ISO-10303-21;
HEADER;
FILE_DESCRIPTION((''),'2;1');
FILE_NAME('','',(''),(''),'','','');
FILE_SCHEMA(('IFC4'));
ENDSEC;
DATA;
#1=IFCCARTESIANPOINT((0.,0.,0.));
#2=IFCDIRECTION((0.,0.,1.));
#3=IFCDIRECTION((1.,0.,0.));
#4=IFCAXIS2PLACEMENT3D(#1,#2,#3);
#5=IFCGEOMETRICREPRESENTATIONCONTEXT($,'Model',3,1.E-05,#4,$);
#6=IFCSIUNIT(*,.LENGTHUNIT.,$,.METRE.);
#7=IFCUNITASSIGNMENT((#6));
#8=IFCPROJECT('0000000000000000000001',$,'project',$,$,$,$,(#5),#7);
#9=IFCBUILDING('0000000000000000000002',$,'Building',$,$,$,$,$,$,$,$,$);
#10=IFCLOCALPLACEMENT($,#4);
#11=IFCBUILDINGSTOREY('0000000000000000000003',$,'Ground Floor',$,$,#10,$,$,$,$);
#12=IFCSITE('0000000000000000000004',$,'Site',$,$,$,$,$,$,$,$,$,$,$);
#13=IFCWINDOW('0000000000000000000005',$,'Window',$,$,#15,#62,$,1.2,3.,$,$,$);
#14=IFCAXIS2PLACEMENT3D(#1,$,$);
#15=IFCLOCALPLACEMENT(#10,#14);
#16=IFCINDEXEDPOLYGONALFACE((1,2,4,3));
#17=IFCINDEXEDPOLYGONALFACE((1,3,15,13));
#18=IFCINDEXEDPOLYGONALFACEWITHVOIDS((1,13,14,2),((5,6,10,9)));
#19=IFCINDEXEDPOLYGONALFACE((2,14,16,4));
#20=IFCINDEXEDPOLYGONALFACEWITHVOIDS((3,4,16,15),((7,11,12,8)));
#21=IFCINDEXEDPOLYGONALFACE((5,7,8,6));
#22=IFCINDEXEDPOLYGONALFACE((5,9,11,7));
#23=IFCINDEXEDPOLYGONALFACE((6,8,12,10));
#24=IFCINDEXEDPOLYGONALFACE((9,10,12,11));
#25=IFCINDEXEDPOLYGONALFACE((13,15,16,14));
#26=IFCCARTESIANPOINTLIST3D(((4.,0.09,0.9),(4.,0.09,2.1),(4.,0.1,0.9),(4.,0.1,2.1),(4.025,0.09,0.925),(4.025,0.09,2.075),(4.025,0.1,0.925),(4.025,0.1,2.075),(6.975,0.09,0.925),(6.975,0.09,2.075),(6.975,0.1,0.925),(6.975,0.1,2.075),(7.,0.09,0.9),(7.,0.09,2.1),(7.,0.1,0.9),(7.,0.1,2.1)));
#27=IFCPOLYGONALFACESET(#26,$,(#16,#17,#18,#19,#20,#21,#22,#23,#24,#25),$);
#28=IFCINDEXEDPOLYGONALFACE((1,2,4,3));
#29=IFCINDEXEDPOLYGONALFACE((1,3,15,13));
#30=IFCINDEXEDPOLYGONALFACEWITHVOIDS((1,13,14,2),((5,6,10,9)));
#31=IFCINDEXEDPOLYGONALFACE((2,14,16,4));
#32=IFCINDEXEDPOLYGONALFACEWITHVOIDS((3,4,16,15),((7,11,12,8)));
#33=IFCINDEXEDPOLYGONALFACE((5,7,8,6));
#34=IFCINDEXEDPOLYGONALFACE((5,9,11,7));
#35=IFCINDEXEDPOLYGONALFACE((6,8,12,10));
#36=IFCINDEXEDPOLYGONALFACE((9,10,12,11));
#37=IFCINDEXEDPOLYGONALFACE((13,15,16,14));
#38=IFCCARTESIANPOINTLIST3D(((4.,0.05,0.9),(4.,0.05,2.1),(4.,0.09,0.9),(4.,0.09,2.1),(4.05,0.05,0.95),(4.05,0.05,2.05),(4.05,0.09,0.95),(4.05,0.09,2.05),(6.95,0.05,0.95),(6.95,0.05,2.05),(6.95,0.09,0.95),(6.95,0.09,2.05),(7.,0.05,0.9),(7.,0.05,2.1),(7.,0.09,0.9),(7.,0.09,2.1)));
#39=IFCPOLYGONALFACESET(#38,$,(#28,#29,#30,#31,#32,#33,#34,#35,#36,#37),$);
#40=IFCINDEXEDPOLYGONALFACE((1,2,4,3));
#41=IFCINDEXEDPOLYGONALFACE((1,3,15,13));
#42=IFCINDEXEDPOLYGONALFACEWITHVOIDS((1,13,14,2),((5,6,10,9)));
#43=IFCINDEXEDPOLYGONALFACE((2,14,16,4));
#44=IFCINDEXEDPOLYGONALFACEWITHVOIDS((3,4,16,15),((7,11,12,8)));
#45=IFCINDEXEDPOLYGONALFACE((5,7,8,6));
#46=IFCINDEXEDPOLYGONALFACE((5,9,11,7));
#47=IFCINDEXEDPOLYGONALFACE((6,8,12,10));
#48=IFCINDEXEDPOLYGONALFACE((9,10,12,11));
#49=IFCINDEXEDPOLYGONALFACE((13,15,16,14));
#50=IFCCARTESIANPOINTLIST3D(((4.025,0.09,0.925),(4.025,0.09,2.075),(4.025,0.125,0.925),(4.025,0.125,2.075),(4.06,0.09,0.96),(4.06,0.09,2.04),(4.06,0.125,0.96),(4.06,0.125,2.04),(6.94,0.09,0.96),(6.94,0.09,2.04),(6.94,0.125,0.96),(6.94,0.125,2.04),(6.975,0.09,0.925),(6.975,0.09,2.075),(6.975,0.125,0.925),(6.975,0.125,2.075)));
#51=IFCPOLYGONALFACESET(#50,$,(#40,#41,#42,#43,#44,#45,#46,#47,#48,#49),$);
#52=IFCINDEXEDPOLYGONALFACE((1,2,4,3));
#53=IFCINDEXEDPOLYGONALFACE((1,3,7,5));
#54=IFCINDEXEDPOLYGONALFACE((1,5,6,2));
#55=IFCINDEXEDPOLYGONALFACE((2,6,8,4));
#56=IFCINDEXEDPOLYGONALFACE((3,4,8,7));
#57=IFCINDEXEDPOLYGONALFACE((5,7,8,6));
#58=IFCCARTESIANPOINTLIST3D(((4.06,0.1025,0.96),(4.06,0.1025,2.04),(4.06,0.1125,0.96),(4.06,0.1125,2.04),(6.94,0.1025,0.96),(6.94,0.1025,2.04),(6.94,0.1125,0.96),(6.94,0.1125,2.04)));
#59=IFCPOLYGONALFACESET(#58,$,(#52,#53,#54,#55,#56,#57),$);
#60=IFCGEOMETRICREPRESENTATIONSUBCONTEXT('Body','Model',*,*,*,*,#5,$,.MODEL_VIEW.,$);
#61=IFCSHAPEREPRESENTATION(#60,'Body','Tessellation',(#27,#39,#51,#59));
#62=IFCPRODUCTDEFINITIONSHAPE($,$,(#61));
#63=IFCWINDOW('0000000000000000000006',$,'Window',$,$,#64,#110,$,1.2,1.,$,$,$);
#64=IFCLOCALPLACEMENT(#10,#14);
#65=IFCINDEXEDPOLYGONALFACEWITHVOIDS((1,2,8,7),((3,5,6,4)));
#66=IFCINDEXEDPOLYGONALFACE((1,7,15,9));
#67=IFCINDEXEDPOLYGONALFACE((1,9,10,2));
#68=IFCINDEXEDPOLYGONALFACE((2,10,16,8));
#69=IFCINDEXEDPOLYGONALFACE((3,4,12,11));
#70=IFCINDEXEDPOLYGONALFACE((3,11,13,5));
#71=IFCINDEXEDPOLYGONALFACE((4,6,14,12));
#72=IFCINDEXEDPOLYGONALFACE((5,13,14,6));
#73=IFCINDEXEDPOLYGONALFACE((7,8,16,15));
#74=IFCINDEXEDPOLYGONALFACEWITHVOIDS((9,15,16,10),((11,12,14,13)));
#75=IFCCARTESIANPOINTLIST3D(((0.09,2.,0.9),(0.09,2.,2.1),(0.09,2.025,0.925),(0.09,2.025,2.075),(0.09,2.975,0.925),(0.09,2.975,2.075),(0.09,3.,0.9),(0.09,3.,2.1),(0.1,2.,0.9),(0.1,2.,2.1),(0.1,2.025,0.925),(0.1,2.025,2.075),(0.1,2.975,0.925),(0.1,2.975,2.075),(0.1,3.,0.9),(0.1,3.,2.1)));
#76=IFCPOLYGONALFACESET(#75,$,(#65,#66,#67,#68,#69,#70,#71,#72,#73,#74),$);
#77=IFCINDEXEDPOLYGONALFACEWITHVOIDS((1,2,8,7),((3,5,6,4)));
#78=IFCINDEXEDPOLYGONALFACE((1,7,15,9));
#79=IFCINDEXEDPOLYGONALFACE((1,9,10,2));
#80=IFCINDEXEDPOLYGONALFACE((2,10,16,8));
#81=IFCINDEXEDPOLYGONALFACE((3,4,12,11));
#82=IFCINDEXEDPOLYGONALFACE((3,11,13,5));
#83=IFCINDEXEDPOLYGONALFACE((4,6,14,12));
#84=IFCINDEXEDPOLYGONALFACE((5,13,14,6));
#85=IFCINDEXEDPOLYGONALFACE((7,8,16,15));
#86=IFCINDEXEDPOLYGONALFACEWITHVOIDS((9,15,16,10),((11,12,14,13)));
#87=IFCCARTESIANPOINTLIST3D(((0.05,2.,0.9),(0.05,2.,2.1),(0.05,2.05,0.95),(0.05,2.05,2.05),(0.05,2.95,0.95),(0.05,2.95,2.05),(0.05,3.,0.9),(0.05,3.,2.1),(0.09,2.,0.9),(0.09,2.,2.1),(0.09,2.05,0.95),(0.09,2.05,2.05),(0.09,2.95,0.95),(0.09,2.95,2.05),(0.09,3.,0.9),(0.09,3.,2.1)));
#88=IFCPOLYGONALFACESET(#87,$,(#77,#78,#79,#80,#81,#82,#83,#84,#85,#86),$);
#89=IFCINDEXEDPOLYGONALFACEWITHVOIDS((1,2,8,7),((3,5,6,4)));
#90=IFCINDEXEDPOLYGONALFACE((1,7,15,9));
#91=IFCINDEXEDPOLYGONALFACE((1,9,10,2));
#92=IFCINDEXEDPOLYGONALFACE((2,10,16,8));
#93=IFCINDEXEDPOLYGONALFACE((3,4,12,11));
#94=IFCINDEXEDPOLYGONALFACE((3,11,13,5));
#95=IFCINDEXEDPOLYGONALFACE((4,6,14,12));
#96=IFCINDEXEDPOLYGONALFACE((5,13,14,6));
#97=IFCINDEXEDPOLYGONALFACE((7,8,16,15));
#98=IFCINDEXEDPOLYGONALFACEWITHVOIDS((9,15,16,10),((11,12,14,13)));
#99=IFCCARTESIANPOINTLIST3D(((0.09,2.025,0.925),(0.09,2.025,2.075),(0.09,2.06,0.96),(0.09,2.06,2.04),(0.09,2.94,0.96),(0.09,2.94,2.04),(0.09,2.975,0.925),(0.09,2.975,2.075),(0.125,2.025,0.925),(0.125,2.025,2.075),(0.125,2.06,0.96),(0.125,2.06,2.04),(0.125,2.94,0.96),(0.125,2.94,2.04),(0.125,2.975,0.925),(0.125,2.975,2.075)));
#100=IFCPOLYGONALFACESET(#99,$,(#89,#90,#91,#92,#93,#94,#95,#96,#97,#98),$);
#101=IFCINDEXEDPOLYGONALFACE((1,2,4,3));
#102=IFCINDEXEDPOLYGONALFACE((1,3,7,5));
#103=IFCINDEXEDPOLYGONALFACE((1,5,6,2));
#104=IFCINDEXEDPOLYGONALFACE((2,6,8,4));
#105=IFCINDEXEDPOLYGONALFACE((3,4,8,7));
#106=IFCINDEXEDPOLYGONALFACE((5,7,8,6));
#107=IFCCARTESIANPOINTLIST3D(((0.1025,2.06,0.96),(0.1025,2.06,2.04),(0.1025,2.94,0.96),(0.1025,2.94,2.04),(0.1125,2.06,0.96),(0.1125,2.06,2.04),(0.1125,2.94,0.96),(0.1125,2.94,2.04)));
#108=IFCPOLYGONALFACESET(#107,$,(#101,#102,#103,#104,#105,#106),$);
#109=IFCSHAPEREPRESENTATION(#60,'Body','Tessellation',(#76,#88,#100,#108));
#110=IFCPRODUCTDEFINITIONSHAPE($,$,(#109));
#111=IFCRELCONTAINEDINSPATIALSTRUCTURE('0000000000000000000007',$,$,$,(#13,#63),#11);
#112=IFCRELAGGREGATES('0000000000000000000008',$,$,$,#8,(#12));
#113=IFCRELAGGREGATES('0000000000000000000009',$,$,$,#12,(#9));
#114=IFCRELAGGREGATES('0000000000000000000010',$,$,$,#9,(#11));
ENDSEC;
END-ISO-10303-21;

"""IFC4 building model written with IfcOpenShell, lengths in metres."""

from ifc_helpers import new_model, si_unit, frame, origin_with_axes, place, context, subcontext, project, spatial, line, indexed_curve, outline, extrude, element, save


model = new_model("IFC4")

# Units and contexts
model_context = context("Model", 3, precision=1e-05, world=origin_with_axes())
body_context = subcontext(model_context, "Body", "Model", "MODEL_VIEW")
ifc_project = project(units=[si_unit("LENGTHUNIT", "METRE")], contexts=[model_context])

# Site, building, storey
site = spatial("IfcSite", under=ifc_project, Name="Site")
building = spatial("IfcBuilding", under=site, Name="Building")
storey_placement = place(None, origin_with_axes())
storey = spatial("IfcBuildingStorey", under=building, at=storey_placement, Name="Ground Floor")

# Windows
window_1_placement = place(storey_placement, frame((4.0, 0.0, 0.9), z_axis=(0.0, 0.0, 1.0), x_axis=(1.0, 0.0, 0.0)))
element("IfcWindow", 1, at=window_1_placement, inside=storey, Name="Window", OverallHeight=1.2, OverallWidth=3.0, context=body_context, shape_type="SweptSolid", body=[
    extrude(outline(indexed_curve([(0.0, 0.0), (3.0, 0.0), (3.0, 1.2), (0.0, 1.2)], segments=[line(1, 2, 3, 4, 1)]), holes=[indexed_curve([(0.025, 0.025), (2.975, 0.025), (2.975, 1.175), (0.025, 1.175)], segments=[line(1, 2, 3, 4, 1)])]), frame((0.0, 0.09, 0.0), z_axis=(0.0, -1.0, 0.0), x_axis=(1.0, 0.0, 0.0)), (0.0, 0.0, -1.0), 0.01),
    extrude(outline(indexed_curve([(0.0, 0.0), (3.0, 0.0), (3.0, 1.2), (0.0, 1.2)], segments=[line(1, 2, 3, 4, 1)]), holes=[indexed_curve([(0.05, 0.05), (2.95, 0.05), (2.95, 1.15), (0.05, 1.15)], segments=[line(1, 2, 3, 4, 1)])]), frame((0.0, 0.05, 0.0), z_axis=(0.0, -1.0, 0.0), x_axis=(1.0, 0.0, 0.0)), (0.0, 0.0, -1.0), 0.04),
    extrude(outline(indexed_curve([(0.0, 0.0), (2.95, 0.0), (2.95, 1.15), (0.0, 1.15)], segments=[line(1, 2, 3, 4, 1)]), holes=[indexed_curve([(0.035, 0.035), (2.915, 0.035), (2.915, 1.115), (0.035, 1.115)], segments=[line(1, 2, 3, 4, 1)])]), frame((0.025, 0.09, 0.025), z_axis=(0.0, -1.0, 0.0), x_axis=(1.0, 0.0, 0.0)), (0.0, 0.0, -1.0), 0.035),
    extrude(outline(indexed_curve([(0.035, 0.035), (2.915, 0.035), (2.915, 1.115), (0.035, 1.115)], segments=[line(1, 2, 3, 4, 1)])), frame((0.025, 0.1025, 0.025), z_axis=(0.0, -1.0, 0.0), x_axis=(1.0, 0.0, 0.0)), (0.0, 0.0, -1.0), 0.01),
])
window_2_placement = place(storey_placement, frame((0.0, 3.0, 0.9), z_axis=(0.0, 0.0, 1.0), x_axis=(0.0, -1.0, 0.0)))
element("IfcWindow", 2, at=window_2_placement, inside=storey, Name="Window", OverallHeight=1.2, OverallWidth=1.0, context=body_context, shape_type="SweptSolid", body=[
    extrude(outline(indexed_curve([(0.0, 0.0), (1.0, 0.0), (1.0, 1.2), (0.0, 1.2)], segments=[line(1, 2, 3, 4, 1)]), holes=[indexed_curve([(0.025, 0.025), (0.975, 0.025), (0.975, 1.175), (0.025, 1.175)], segments=[line(1, 2, 3, 4, 1)])]), frame((0.0, 0.09, 0.0), z_axis=(0.0, -1.0, 0.0), x_axis=(1.0, 0.0, 0.0)), (0.0, 0.0, -1.0), 0.01),
    extrude(outline(indexed_curve([(0.0, 0.0), (1.0, 0.0), (1.0, 1.2), (0.0, 1.2)], segments=[line(1, 2, 3, 4, 1)]), holes=[indexed_curve([(0.05, 0.05), (0.95, 0.05), (0.95, 1.15), (0.05, 1.15)], segments=[line(1, 2, 3, 4, 1)])]), frame((0.0, 0.05, 0.0), z_axis=(0.0, -1.0, 0.0), x_axis=(1.0, 0.0, 0.0)), (0.0, 0.0, -1.0), 0.04),
    extrude(outline(indexed_curve([(0.0, 0.0), (0.95, 0.0), (0.95, 1.15), (0.0, 1.15)], segments=[line(1, 2, 3, 4, 1)]), holes=[indexed_curve([(0.035, 0.035), (0.915, 0.035), (0.915, 1.115), (0.035, 1.115)], segments=[line(1, 2, 3, 4, 1)])]), frame((0.025, 0.09, 0.025), z_axis=(0.0, -1.0, 0.0), x_axis=(1.0, 0.0, 0.0)), (0.0, 0.0, -1.0), 0.035),
    extrude(outline(indexed_curve([(0.035, 0.035), (0.915, 0.035), (0.915, 1.115), (0.035, 1.115)], segments=[line(1, 2, 3, 4, 1)])), frame((0.025, 0.1025, 0.025), z_axis=(0.0, -1.0, 0.0), x_axis=(1.0, 0.0, 0.0)), (0.0, 0.0, -1.0), 0.01),
])

save(model, "model.ifc")
